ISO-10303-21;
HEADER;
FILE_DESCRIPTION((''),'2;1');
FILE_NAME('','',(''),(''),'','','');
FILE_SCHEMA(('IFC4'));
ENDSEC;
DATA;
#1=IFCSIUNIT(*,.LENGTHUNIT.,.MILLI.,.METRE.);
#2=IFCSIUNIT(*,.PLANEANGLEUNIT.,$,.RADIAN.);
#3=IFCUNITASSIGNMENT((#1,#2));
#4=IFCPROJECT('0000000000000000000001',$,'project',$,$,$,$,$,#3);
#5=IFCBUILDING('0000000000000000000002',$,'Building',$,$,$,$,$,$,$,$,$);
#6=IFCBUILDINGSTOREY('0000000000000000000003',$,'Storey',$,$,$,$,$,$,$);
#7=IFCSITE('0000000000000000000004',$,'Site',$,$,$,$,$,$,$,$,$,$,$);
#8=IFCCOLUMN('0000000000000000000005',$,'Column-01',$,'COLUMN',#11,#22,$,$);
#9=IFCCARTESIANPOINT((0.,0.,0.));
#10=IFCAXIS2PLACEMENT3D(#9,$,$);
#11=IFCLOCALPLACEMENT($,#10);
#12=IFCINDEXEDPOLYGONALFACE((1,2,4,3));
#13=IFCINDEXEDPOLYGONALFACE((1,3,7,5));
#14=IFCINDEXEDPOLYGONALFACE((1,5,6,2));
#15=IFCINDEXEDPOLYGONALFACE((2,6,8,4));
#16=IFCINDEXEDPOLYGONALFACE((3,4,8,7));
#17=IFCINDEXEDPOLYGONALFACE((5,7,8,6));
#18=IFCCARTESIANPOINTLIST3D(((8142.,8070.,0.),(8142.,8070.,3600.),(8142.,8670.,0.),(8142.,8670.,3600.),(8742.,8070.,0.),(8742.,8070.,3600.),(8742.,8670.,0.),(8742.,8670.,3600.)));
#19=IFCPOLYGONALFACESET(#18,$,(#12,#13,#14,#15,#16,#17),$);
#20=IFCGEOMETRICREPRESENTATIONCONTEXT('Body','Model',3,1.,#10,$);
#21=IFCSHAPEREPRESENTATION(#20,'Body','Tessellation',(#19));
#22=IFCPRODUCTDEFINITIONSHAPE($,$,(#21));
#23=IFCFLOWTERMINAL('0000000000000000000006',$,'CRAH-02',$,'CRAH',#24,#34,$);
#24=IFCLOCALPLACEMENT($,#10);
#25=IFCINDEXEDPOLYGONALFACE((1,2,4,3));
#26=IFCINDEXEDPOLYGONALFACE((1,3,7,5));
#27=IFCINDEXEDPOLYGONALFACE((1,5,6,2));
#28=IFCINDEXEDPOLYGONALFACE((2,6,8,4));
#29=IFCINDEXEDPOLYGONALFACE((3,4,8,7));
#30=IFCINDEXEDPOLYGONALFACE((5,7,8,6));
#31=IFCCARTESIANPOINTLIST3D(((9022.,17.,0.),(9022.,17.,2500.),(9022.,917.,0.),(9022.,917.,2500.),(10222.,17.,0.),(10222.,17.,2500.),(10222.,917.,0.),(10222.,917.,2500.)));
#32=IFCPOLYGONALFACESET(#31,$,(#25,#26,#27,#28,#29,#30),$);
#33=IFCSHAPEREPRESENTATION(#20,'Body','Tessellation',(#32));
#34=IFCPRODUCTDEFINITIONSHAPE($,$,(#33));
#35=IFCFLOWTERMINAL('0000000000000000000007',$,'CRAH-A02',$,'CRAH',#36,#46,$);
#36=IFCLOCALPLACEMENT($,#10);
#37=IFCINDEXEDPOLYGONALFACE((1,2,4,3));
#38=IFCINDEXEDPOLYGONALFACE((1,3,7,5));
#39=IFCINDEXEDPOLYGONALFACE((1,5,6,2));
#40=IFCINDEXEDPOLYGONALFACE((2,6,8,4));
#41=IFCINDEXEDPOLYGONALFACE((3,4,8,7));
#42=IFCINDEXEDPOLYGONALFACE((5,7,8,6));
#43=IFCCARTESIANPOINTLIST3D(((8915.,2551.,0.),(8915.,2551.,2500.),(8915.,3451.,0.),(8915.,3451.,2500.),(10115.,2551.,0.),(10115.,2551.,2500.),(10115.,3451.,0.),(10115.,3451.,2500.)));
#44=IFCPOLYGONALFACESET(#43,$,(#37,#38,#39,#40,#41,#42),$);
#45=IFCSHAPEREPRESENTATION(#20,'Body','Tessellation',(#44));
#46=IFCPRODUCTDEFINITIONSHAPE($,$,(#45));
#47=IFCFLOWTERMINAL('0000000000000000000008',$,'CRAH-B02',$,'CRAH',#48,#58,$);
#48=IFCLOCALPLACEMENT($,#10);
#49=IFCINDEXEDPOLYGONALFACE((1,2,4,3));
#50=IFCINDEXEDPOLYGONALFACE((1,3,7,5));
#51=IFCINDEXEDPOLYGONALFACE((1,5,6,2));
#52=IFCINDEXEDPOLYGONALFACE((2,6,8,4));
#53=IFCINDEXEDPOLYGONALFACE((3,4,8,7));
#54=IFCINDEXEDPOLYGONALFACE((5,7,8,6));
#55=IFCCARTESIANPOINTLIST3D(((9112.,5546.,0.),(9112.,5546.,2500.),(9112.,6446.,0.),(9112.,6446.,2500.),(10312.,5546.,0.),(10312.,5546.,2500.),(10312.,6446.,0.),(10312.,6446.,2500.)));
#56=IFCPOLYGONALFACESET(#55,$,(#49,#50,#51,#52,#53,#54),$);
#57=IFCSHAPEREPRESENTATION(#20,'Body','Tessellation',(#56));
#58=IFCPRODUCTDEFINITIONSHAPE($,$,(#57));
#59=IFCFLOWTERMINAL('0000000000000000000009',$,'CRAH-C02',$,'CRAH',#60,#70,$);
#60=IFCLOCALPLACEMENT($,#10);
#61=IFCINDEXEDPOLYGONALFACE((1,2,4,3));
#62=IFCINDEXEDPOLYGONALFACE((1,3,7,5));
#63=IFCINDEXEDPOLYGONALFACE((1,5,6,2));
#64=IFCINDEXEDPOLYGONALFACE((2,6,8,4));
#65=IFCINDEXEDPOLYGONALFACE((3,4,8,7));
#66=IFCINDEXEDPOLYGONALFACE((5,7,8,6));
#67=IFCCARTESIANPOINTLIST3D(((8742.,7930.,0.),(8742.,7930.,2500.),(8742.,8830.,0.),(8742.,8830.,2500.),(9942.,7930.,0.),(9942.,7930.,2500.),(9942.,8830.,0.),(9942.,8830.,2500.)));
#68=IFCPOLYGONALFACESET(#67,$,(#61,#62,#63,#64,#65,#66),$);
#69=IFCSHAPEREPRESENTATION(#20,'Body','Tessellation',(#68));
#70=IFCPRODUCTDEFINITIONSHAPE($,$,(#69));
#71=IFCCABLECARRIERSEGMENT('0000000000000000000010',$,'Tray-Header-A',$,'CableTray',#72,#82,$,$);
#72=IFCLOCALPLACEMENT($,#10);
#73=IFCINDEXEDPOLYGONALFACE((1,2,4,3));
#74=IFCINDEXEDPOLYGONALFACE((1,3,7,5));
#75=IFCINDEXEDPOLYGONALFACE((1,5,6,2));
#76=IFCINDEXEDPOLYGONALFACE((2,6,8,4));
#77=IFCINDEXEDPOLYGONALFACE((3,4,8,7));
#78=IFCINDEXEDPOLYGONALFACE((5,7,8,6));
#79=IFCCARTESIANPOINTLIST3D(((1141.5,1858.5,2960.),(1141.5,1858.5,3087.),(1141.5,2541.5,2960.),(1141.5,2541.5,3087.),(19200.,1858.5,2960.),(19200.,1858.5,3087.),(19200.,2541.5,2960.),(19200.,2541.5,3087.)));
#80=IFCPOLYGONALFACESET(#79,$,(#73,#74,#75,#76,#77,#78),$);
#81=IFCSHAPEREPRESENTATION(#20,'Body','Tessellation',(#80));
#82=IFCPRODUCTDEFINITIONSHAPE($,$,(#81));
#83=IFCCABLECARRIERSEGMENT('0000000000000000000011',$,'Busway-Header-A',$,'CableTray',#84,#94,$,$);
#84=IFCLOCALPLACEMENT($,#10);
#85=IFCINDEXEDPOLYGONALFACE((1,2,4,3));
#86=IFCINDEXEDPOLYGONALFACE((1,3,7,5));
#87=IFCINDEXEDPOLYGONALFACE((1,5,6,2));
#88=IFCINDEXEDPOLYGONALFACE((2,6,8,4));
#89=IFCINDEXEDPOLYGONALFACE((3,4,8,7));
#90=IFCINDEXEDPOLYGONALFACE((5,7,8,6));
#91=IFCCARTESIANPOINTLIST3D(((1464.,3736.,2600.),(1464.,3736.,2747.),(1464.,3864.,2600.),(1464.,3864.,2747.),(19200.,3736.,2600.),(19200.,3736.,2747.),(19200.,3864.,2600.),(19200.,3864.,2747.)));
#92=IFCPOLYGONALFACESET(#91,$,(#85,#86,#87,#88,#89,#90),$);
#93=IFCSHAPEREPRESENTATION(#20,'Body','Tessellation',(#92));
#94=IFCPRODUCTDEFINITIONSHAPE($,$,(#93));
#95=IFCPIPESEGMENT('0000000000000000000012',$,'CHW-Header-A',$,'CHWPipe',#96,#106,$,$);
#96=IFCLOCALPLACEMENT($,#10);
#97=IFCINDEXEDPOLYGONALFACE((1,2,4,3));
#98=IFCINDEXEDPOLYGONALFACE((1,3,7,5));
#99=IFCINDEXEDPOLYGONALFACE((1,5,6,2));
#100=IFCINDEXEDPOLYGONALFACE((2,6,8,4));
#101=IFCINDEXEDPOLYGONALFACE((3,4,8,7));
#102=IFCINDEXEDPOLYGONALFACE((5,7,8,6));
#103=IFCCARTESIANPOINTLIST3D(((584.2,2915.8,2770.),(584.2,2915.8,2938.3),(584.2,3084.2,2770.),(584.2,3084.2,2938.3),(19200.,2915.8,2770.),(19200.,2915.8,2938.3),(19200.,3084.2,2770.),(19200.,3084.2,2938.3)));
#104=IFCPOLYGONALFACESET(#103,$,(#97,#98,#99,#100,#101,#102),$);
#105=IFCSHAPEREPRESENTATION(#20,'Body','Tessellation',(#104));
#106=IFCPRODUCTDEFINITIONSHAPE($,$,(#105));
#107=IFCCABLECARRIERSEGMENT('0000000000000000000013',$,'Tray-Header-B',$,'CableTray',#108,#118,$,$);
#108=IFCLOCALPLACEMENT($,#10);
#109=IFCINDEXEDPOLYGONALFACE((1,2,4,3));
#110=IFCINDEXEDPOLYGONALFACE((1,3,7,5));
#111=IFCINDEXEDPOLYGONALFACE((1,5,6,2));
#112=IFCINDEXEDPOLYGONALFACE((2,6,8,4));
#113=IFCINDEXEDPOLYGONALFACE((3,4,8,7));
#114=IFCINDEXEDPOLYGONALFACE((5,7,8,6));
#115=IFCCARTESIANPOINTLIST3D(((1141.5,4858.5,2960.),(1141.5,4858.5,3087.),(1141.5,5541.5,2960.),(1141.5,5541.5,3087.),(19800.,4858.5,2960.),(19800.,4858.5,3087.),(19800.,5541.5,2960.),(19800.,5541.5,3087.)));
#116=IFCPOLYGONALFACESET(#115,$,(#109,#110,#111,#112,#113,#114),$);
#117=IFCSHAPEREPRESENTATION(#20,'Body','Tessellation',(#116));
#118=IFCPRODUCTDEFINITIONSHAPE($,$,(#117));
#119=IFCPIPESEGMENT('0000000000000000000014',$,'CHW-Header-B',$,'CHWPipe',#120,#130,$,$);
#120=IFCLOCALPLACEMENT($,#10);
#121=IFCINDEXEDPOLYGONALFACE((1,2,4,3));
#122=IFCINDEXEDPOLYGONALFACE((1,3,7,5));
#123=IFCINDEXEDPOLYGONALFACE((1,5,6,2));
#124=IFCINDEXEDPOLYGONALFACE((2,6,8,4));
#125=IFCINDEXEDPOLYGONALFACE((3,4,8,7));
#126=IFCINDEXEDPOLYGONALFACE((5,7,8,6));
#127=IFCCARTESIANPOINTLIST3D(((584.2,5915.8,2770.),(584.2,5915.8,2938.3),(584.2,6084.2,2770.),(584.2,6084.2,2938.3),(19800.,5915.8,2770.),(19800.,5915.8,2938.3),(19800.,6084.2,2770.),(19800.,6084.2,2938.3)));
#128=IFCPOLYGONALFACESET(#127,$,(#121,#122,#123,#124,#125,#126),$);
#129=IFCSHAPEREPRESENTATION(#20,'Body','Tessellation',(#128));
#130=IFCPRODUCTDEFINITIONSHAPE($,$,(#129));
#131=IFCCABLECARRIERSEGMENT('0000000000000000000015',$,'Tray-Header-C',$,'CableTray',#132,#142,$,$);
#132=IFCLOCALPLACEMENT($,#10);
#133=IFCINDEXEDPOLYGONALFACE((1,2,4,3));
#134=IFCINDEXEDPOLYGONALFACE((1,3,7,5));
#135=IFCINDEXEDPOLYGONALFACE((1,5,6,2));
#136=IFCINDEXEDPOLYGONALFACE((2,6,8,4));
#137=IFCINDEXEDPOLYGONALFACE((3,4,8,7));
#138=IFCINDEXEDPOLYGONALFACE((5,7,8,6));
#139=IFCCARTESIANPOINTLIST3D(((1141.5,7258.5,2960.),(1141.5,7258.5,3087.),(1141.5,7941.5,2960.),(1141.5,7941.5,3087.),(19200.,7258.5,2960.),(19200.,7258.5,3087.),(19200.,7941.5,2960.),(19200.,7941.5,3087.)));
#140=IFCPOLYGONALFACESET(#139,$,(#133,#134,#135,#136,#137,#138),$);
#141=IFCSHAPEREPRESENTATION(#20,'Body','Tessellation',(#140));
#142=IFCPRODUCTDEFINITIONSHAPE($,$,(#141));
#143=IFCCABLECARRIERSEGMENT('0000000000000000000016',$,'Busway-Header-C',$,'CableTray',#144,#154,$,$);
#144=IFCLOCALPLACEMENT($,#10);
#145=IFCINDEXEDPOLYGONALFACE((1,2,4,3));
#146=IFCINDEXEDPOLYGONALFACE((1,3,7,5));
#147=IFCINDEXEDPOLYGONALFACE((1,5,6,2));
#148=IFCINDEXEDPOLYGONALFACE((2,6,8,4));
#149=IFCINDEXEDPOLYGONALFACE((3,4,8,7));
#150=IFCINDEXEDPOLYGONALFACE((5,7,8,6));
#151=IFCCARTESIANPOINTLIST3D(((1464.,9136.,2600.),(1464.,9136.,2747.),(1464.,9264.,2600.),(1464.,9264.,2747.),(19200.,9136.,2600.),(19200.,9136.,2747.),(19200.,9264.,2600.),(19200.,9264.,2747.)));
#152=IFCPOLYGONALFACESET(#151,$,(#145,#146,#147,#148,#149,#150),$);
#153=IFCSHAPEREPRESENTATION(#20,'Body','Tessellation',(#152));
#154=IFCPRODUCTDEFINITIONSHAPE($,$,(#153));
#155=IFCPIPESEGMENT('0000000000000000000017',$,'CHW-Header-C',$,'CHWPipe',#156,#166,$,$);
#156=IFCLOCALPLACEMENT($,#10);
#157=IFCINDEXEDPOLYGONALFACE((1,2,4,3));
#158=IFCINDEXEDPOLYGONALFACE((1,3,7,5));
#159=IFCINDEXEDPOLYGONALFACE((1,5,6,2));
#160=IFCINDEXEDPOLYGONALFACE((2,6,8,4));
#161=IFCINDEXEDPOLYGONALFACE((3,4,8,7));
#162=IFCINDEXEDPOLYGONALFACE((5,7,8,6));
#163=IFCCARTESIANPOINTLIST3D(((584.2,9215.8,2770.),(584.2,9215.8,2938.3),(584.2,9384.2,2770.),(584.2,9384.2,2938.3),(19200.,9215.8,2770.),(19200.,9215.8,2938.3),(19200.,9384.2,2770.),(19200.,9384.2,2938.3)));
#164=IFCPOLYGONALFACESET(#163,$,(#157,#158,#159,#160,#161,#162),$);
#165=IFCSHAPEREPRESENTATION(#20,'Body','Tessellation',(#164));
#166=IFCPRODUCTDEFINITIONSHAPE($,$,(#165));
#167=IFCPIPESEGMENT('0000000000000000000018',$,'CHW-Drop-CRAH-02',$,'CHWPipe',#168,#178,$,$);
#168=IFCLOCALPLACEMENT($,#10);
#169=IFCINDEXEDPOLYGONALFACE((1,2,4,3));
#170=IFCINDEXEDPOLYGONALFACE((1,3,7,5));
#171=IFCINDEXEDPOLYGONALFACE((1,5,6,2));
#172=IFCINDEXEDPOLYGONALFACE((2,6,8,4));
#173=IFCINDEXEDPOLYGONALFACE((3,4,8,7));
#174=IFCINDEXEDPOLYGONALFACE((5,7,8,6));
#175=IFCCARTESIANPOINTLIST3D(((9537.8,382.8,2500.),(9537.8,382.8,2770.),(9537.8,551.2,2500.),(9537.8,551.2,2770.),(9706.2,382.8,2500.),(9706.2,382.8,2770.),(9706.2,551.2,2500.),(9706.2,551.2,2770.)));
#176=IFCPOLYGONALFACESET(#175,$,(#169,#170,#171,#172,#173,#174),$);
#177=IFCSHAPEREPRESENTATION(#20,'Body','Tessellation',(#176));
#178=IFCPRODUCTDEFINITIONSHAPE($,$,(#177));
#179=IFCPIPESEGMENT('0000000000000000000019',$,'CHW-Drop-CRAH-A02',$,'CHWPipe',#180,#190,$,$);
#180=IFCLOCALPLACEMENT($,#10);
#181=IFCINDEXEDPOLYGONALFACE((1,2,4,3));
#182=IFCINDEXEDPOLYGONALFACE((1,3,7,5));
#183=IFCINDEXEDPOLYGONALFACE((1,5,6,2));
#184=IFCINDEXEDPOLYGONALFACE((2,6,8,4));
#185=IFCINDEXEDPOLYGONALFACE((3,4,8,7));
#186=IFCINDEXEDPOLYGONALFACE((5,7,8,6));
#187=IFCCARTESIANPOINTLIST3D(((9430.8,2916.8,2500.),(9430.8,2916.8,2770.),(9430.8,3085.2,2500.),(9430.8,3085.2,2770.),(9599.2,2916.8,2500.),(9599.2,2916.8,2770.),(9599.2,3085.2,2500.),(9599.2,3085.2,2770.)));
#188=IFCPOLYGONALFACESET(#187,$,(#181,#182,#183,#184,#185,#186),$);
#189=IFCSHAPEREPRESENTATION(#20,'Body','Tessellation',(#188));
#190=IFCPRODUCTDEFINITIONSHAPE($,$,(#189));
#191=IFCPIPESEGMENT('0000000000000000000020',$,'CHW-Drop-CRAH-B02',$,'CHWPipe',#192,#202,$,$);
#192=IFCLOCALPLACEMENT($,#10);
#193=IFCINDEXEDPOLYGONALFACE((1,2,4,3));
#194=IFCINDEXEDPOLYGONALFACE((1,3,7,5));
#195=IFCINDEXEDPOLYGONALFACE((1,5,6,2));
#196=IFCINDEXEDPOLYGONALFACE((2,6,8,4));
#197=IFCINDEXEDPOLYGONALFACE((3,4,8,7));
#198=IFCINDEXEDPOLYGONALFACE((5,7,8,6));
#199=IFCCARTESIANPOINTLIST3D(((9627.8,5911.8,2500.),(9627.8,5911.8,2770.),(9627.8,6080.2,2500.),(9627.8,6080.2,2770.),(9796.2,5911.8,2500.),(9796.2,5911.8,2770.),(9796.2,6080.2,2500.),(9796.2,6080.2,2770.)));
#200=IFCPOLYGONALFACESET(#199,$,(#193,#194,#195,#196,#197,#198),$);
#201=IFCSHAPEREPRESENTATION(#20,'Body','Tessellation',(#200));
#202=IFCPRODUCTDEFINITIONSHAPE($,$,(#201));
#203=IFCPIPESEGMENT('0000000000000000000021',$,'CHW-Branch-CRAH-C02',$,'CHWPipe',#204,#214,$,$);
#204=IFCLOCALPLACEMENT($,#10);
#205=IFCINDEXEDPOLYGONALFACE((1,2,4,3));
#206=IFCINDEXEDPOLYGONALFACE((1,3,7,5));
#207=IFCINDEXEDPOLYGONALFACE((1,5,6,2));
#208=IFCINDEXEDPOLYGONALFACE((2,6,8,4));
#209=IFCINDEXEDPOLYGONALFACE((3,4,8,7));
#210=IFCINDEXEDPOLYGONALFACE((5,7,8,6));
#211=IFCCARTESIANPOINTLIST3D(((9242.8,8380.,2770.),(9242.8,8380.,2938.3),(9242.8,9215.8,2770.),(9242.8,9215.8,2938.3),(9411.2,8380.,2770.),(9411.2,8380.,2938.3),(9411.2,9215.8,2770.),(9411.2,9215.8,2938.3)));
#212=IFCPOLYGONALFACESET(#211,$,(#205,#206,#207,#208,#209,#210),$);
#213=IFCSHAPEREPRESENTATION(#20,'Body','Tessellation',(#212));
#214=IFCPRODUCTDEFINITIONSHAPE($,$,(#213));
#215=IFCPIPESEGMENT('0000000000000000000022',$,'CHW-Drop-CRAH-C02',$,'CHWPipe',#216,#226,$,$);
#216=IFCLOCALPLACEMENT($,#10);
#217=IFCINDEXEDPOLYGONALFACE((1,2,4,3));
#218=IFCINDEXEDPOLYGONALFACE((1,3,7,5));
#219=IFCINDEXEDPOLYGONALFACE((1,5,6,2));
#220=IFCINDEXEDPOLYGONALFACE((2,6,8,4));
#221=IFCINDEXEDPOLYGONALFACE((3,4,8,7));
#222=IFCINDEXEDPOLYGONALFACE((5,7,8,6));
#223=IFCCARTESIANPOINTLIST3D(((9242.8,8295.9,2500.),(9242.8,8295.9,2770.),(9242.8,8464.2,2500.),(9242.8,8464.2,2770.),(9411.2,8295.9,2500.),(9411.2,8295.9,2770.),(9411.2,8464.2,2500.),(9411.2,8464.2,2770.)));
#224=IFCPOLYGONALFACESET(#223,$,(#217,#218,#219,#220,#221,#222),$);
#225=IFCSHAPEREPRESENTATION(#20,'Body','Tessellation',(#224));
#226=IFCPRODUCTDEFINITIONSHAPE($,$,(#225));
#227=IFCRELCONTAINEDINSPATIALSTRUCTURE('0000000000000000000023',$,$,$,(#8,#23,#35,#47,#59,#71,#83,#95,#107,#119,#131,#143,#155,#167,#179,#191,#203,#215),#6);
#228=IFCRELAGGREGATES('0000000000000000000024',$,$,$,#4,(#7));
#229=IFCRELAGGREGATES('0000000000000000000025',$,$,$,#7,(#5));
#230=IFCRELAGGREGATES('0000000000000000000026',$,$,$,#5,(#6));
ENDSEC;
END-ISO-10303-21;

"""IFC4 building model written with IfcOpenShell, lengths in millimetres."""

from ifc_helpers import new_model, si_unit, frame, origin, place, context, project, spatial, rectangle, extrude, element, save


model = new_model("IFC4")

# Units and contexts
model_context = context("Model", 3, precision=1.0, world=origin(), identifier="Body")
ifc_project = project(units=[si_unit("LENGTHUNIT", "METRE", prefix="MILLI"), si_unit("PLANEANGLEUNIT", "RADIAN")])

# Site, building, storey
site = spatial("IfcSite", under=ifc_project, Name="Site")
building = spatial("IfcBuilding", under=site, Name="Building")
storey = spatial("IfcBuildingStorey", under=building, Name="Storey")

# Column
column_placement = place(None, frame((8442.0, 8370.0, 0.0), z_axis=(0.0, 0.0, 1.0), x_axis=(1.0, 0.0, 0.0)))
element("IfcColumn", 1, at=column_placement, inside=storey, Name="Column-01", ObjectType="COLUMN", context=model_context, shape_type="SweptSolid", body=[
    extrude(rectangle(XDim=600.0, YDim=600.0), origin(), (0.0, 0.0, 1.0), 3600.0),
])

# Flow terminals
for number, where, z_axis, x_axis, name in (
    (2, (9622.0, 467.0, 0.0), (0.0, 0.0, 1.0), (1.0, 0.0, 0.0), "CRAH-02"),
    (3, (9515.0, 3001.0, 0.0), (0.0, 0.0, 1.0), (1.0, 0.0, 0.0), "CRAH-A02"),
    (4, (9712.0, 5996.0, 0.0), (0.0, 0.0, 1.0), (1.0, 0.0, 0.0), "CRAH-B02"),
    (5, (9342.0, 8380.0, 0.0), (0.0, 0.0, 1.0), (1.0, 0.0, 0.0), "CRAH-C02"),
):
    element("IfcFlowTerminal", number, at=place(None, frame(where, z_axis=z_axis, x_axis=x_axis)), inside=storey, Name=name, ObjectType="CRAH", context=model_context, shape_type="SweptSolid", body=[
        extrude(rectangle(XDim=1200.0, YDim=900.0), origin(), (0.0, 0.0, 1.0), 2500.0),
    ])

# Cable carrier segments
cable_carrier_segment_1_placement = place(None, frame((10170.8, 2200.0, 2960.0), z_axis=(0.0, 0.0, 1.0), x_axis=(1.0, 0.0, 0.0)))
element("IfcCableCarrierSegment", 6, at=cable_carrier_segment_1_placement, inside=storey, Name="Tray-Header-A", ObjectType="CableTray", context=model_context, shape_type="SweptSolid", body=[
    extrude(rectangle(XDim=18058.5, YDim=683.0), origin(), (0.0, 0.0, 1.0), 127.0),
])
cable_carrier_segment_2_placement = place(None, frame((10332.0, 3800.0, 2600.0), z_axis=(0.0, 0.0, 1.0), x_axis=(1.0, 0.0, 0.0)))
element("IfcCableCarrierSegment", 7, at=cable_carrier_segment_2_placement, inside=storey, Name="Busway-Header-A", ObjectType="CableTray", context=model_context, shape_type="SweptSolid", body=[
    extrude(rectangle(XDim=17736.0, YDim=128.0), origin(), (0.0, 0.0, 1.0), 147.0),
])

# Pipe segment
pipe_segment_1_placement = place(None, frame((9892.1, 3000.0, 2770.0), z_axis=(0.0, 0.0, 1.0), x_axis=(1.0, 0.0, 0.0)))
element("IfcPipeSegment", 8, at=pipe_segment_1_placement, inside=storey, Name="CHW-Header-A", ObjectType="CHWPipe", context=model_context, shape_type="SweptSolid", body=[
    extrude(rectangle(XDim=18615.8, YDim=168.3), origin(), (0.0, 0.0, 1.0), 168.3),
])

# Cable carrier segment
cable_carrier_segment_3_placement = place(None, frame((10470.8, 5200.0, 2960.0), z_axis=(0.0, 0.0, 1.0), x_axis=(1.0, 0.0, 0.0)))
element("IfcCableCarrierSegment", 9, at=cable_carrier_segment_3_placement, inside=storey, Name="Tray-Header-B", ObjectType="CableTray", context=model_context, shape_type="SweptSolid", body=[
    extrude(rectangle(XDim=18658.5, YDim=683.0), origin(), (0.0, 0.0, 1.0), 127.0),
])

# Pipe segment
pipe_segment_2_placement = place(None, frame((10192.1, 6000.0, 2770.0), z_axis=(0.0, 0.0, 1.0), x_axis=(1.0, 0.0, 0.0)))
element("IfcPipeSegment", 10, at=pipe_segment_2_placement, inside=storey, Name="CHW-Header-B", ObjectType="CHWPipe", context=model_context, shape_type="SweptSolid", body=[
    extrude(rectangle(XDim=19215.8, YDim=168.3), origin(), (0.0, 0.0, 1.0), 168.3),
])

# Cable carrier segments
cable_carrier_segment_4_placement = place(None, frame((10170.8, 7600.0, 2960.0), z_axis=(0.0, 0.0, 1.0), x_axis=(1.0, 0.0, 0.0)))
element("IfcCableCarrierSegment", 11, at=cable_carrier_segment_4_placement, inside=storey, Name="Tray-Header-C", ObjectType="CableTray", context=model_context, shape_type="SweptSolid", body=[
    extrude(rectangle(XDim=18058.5, YDim=683.0), origin(), (0.0, 0.0, 1.0), 127.0),
])
cable_carrier_segment_5_placement = place(None, frame((10332.0, 9200.0, 2600.0), z_axis=(0.0, 0.0, 1.0), x_axis=(1.0, 0.0, 0.0)))
element("IfcCableCarrierSegment", 12, at=cable_carrier_segment_5_placement, inside=storey, Name="Busway-Header-C", ObjectType="CableTray", context=model_context, shape_type="SweptSolid", body=[
    extrude(rectangle(XDim=17736.0, YDim=128.0), origin(), (0.0, 0.0, 1.0), 147.0),
])

# Pipe segments
pipe_segment_3_placement = place(None, frame((9892.1, 9300.0, 2770.0), z_axis=(0.0, 0.0, 1.0), x_axis=(1.0, 0.0, 0.0)))
element("IfcPipeSegment", 13, at=pipe_segment_3_placement, inside=storey, Name="CHW-Header-C", ObjectType="CHWPipe", context=model_context, shape_type="SweptSolid", body=[
    extrude(rectangle(XDim=18615.8, YDim=168.3), origin(), (0.0, 0.0, 1.0), 168.3),
])
for number, where, z_axis, x_axis, name in (
    (14, (9622.0, 467.0, 2500.0), (0.0, 0.0, 1.0), (1.0, 0.0, 0.0), "CHW-Drop-CRAH-02"),
    (15, (9515.0, 3001.0, 2500.0), (0.0, 0.0, 1.0), (1.0, 0.0, 0.0), "CHW-Drop-CRAH-A02"),
    (16, (9712.0, 5996.0, 2500.0), (0.0, 0.0, 1.0), (1.0, 0.0, 0.0), "CHW-Drop-CRAH-B02"),
):
    element("IfcPipeSegment", number, at=place(None, frame(where, z_axis=z_axis, x_axis=x_axis)), inside=storey, Name=name, ObjectType="CHWPipe", context=model_context, shape_type="SweptSolid", body=[
        extrude(rectangle(XDim=168.3, YDim=168.3), origin(), (0.0, 0.0, 1.0), 270.0),
    ])
pipe_segment_4_placement = place(None, frame((9327.0, 8797.9, 2770.0), z_axis=(0.0, 0.0, 1.0), x_axis=(1.0, 0.0, 0.0)))
element("IfcPipeSegment", 17, at=pipe_segment_4_placement, inside=storey, Name="CHW-Branch-CRAH-C02", ObjectType="CHWPipe", context=model_context, shape_type="SweptSolid", body=[
    extrude(rectangle(XDim=168.3, YDim=835.9), origin(), (0.0, 0.0, 1.0), 168.3),
])
pipe_segment_5_placement = place(None, frame((9327.0, 8380.0, 2500.0), z_axis=(0.0, 0.0, 1.0), x_axis=(1.0, 0.0, 0.0)))
element("IfcPipeSegment", 18, at=pipe_segment_5_placement, inside=storey, Name="CHW-Drop-CRAH-C02", ObjectType="CHWPipe", context=model_context, shape_type="SweptSolid", body=[
    extrude(rectangle(XDim=168.3, YDim=168.3), origin(), (0.0, 0.0, 1.0), 270.0),
])

save(model, "model.ifc")
